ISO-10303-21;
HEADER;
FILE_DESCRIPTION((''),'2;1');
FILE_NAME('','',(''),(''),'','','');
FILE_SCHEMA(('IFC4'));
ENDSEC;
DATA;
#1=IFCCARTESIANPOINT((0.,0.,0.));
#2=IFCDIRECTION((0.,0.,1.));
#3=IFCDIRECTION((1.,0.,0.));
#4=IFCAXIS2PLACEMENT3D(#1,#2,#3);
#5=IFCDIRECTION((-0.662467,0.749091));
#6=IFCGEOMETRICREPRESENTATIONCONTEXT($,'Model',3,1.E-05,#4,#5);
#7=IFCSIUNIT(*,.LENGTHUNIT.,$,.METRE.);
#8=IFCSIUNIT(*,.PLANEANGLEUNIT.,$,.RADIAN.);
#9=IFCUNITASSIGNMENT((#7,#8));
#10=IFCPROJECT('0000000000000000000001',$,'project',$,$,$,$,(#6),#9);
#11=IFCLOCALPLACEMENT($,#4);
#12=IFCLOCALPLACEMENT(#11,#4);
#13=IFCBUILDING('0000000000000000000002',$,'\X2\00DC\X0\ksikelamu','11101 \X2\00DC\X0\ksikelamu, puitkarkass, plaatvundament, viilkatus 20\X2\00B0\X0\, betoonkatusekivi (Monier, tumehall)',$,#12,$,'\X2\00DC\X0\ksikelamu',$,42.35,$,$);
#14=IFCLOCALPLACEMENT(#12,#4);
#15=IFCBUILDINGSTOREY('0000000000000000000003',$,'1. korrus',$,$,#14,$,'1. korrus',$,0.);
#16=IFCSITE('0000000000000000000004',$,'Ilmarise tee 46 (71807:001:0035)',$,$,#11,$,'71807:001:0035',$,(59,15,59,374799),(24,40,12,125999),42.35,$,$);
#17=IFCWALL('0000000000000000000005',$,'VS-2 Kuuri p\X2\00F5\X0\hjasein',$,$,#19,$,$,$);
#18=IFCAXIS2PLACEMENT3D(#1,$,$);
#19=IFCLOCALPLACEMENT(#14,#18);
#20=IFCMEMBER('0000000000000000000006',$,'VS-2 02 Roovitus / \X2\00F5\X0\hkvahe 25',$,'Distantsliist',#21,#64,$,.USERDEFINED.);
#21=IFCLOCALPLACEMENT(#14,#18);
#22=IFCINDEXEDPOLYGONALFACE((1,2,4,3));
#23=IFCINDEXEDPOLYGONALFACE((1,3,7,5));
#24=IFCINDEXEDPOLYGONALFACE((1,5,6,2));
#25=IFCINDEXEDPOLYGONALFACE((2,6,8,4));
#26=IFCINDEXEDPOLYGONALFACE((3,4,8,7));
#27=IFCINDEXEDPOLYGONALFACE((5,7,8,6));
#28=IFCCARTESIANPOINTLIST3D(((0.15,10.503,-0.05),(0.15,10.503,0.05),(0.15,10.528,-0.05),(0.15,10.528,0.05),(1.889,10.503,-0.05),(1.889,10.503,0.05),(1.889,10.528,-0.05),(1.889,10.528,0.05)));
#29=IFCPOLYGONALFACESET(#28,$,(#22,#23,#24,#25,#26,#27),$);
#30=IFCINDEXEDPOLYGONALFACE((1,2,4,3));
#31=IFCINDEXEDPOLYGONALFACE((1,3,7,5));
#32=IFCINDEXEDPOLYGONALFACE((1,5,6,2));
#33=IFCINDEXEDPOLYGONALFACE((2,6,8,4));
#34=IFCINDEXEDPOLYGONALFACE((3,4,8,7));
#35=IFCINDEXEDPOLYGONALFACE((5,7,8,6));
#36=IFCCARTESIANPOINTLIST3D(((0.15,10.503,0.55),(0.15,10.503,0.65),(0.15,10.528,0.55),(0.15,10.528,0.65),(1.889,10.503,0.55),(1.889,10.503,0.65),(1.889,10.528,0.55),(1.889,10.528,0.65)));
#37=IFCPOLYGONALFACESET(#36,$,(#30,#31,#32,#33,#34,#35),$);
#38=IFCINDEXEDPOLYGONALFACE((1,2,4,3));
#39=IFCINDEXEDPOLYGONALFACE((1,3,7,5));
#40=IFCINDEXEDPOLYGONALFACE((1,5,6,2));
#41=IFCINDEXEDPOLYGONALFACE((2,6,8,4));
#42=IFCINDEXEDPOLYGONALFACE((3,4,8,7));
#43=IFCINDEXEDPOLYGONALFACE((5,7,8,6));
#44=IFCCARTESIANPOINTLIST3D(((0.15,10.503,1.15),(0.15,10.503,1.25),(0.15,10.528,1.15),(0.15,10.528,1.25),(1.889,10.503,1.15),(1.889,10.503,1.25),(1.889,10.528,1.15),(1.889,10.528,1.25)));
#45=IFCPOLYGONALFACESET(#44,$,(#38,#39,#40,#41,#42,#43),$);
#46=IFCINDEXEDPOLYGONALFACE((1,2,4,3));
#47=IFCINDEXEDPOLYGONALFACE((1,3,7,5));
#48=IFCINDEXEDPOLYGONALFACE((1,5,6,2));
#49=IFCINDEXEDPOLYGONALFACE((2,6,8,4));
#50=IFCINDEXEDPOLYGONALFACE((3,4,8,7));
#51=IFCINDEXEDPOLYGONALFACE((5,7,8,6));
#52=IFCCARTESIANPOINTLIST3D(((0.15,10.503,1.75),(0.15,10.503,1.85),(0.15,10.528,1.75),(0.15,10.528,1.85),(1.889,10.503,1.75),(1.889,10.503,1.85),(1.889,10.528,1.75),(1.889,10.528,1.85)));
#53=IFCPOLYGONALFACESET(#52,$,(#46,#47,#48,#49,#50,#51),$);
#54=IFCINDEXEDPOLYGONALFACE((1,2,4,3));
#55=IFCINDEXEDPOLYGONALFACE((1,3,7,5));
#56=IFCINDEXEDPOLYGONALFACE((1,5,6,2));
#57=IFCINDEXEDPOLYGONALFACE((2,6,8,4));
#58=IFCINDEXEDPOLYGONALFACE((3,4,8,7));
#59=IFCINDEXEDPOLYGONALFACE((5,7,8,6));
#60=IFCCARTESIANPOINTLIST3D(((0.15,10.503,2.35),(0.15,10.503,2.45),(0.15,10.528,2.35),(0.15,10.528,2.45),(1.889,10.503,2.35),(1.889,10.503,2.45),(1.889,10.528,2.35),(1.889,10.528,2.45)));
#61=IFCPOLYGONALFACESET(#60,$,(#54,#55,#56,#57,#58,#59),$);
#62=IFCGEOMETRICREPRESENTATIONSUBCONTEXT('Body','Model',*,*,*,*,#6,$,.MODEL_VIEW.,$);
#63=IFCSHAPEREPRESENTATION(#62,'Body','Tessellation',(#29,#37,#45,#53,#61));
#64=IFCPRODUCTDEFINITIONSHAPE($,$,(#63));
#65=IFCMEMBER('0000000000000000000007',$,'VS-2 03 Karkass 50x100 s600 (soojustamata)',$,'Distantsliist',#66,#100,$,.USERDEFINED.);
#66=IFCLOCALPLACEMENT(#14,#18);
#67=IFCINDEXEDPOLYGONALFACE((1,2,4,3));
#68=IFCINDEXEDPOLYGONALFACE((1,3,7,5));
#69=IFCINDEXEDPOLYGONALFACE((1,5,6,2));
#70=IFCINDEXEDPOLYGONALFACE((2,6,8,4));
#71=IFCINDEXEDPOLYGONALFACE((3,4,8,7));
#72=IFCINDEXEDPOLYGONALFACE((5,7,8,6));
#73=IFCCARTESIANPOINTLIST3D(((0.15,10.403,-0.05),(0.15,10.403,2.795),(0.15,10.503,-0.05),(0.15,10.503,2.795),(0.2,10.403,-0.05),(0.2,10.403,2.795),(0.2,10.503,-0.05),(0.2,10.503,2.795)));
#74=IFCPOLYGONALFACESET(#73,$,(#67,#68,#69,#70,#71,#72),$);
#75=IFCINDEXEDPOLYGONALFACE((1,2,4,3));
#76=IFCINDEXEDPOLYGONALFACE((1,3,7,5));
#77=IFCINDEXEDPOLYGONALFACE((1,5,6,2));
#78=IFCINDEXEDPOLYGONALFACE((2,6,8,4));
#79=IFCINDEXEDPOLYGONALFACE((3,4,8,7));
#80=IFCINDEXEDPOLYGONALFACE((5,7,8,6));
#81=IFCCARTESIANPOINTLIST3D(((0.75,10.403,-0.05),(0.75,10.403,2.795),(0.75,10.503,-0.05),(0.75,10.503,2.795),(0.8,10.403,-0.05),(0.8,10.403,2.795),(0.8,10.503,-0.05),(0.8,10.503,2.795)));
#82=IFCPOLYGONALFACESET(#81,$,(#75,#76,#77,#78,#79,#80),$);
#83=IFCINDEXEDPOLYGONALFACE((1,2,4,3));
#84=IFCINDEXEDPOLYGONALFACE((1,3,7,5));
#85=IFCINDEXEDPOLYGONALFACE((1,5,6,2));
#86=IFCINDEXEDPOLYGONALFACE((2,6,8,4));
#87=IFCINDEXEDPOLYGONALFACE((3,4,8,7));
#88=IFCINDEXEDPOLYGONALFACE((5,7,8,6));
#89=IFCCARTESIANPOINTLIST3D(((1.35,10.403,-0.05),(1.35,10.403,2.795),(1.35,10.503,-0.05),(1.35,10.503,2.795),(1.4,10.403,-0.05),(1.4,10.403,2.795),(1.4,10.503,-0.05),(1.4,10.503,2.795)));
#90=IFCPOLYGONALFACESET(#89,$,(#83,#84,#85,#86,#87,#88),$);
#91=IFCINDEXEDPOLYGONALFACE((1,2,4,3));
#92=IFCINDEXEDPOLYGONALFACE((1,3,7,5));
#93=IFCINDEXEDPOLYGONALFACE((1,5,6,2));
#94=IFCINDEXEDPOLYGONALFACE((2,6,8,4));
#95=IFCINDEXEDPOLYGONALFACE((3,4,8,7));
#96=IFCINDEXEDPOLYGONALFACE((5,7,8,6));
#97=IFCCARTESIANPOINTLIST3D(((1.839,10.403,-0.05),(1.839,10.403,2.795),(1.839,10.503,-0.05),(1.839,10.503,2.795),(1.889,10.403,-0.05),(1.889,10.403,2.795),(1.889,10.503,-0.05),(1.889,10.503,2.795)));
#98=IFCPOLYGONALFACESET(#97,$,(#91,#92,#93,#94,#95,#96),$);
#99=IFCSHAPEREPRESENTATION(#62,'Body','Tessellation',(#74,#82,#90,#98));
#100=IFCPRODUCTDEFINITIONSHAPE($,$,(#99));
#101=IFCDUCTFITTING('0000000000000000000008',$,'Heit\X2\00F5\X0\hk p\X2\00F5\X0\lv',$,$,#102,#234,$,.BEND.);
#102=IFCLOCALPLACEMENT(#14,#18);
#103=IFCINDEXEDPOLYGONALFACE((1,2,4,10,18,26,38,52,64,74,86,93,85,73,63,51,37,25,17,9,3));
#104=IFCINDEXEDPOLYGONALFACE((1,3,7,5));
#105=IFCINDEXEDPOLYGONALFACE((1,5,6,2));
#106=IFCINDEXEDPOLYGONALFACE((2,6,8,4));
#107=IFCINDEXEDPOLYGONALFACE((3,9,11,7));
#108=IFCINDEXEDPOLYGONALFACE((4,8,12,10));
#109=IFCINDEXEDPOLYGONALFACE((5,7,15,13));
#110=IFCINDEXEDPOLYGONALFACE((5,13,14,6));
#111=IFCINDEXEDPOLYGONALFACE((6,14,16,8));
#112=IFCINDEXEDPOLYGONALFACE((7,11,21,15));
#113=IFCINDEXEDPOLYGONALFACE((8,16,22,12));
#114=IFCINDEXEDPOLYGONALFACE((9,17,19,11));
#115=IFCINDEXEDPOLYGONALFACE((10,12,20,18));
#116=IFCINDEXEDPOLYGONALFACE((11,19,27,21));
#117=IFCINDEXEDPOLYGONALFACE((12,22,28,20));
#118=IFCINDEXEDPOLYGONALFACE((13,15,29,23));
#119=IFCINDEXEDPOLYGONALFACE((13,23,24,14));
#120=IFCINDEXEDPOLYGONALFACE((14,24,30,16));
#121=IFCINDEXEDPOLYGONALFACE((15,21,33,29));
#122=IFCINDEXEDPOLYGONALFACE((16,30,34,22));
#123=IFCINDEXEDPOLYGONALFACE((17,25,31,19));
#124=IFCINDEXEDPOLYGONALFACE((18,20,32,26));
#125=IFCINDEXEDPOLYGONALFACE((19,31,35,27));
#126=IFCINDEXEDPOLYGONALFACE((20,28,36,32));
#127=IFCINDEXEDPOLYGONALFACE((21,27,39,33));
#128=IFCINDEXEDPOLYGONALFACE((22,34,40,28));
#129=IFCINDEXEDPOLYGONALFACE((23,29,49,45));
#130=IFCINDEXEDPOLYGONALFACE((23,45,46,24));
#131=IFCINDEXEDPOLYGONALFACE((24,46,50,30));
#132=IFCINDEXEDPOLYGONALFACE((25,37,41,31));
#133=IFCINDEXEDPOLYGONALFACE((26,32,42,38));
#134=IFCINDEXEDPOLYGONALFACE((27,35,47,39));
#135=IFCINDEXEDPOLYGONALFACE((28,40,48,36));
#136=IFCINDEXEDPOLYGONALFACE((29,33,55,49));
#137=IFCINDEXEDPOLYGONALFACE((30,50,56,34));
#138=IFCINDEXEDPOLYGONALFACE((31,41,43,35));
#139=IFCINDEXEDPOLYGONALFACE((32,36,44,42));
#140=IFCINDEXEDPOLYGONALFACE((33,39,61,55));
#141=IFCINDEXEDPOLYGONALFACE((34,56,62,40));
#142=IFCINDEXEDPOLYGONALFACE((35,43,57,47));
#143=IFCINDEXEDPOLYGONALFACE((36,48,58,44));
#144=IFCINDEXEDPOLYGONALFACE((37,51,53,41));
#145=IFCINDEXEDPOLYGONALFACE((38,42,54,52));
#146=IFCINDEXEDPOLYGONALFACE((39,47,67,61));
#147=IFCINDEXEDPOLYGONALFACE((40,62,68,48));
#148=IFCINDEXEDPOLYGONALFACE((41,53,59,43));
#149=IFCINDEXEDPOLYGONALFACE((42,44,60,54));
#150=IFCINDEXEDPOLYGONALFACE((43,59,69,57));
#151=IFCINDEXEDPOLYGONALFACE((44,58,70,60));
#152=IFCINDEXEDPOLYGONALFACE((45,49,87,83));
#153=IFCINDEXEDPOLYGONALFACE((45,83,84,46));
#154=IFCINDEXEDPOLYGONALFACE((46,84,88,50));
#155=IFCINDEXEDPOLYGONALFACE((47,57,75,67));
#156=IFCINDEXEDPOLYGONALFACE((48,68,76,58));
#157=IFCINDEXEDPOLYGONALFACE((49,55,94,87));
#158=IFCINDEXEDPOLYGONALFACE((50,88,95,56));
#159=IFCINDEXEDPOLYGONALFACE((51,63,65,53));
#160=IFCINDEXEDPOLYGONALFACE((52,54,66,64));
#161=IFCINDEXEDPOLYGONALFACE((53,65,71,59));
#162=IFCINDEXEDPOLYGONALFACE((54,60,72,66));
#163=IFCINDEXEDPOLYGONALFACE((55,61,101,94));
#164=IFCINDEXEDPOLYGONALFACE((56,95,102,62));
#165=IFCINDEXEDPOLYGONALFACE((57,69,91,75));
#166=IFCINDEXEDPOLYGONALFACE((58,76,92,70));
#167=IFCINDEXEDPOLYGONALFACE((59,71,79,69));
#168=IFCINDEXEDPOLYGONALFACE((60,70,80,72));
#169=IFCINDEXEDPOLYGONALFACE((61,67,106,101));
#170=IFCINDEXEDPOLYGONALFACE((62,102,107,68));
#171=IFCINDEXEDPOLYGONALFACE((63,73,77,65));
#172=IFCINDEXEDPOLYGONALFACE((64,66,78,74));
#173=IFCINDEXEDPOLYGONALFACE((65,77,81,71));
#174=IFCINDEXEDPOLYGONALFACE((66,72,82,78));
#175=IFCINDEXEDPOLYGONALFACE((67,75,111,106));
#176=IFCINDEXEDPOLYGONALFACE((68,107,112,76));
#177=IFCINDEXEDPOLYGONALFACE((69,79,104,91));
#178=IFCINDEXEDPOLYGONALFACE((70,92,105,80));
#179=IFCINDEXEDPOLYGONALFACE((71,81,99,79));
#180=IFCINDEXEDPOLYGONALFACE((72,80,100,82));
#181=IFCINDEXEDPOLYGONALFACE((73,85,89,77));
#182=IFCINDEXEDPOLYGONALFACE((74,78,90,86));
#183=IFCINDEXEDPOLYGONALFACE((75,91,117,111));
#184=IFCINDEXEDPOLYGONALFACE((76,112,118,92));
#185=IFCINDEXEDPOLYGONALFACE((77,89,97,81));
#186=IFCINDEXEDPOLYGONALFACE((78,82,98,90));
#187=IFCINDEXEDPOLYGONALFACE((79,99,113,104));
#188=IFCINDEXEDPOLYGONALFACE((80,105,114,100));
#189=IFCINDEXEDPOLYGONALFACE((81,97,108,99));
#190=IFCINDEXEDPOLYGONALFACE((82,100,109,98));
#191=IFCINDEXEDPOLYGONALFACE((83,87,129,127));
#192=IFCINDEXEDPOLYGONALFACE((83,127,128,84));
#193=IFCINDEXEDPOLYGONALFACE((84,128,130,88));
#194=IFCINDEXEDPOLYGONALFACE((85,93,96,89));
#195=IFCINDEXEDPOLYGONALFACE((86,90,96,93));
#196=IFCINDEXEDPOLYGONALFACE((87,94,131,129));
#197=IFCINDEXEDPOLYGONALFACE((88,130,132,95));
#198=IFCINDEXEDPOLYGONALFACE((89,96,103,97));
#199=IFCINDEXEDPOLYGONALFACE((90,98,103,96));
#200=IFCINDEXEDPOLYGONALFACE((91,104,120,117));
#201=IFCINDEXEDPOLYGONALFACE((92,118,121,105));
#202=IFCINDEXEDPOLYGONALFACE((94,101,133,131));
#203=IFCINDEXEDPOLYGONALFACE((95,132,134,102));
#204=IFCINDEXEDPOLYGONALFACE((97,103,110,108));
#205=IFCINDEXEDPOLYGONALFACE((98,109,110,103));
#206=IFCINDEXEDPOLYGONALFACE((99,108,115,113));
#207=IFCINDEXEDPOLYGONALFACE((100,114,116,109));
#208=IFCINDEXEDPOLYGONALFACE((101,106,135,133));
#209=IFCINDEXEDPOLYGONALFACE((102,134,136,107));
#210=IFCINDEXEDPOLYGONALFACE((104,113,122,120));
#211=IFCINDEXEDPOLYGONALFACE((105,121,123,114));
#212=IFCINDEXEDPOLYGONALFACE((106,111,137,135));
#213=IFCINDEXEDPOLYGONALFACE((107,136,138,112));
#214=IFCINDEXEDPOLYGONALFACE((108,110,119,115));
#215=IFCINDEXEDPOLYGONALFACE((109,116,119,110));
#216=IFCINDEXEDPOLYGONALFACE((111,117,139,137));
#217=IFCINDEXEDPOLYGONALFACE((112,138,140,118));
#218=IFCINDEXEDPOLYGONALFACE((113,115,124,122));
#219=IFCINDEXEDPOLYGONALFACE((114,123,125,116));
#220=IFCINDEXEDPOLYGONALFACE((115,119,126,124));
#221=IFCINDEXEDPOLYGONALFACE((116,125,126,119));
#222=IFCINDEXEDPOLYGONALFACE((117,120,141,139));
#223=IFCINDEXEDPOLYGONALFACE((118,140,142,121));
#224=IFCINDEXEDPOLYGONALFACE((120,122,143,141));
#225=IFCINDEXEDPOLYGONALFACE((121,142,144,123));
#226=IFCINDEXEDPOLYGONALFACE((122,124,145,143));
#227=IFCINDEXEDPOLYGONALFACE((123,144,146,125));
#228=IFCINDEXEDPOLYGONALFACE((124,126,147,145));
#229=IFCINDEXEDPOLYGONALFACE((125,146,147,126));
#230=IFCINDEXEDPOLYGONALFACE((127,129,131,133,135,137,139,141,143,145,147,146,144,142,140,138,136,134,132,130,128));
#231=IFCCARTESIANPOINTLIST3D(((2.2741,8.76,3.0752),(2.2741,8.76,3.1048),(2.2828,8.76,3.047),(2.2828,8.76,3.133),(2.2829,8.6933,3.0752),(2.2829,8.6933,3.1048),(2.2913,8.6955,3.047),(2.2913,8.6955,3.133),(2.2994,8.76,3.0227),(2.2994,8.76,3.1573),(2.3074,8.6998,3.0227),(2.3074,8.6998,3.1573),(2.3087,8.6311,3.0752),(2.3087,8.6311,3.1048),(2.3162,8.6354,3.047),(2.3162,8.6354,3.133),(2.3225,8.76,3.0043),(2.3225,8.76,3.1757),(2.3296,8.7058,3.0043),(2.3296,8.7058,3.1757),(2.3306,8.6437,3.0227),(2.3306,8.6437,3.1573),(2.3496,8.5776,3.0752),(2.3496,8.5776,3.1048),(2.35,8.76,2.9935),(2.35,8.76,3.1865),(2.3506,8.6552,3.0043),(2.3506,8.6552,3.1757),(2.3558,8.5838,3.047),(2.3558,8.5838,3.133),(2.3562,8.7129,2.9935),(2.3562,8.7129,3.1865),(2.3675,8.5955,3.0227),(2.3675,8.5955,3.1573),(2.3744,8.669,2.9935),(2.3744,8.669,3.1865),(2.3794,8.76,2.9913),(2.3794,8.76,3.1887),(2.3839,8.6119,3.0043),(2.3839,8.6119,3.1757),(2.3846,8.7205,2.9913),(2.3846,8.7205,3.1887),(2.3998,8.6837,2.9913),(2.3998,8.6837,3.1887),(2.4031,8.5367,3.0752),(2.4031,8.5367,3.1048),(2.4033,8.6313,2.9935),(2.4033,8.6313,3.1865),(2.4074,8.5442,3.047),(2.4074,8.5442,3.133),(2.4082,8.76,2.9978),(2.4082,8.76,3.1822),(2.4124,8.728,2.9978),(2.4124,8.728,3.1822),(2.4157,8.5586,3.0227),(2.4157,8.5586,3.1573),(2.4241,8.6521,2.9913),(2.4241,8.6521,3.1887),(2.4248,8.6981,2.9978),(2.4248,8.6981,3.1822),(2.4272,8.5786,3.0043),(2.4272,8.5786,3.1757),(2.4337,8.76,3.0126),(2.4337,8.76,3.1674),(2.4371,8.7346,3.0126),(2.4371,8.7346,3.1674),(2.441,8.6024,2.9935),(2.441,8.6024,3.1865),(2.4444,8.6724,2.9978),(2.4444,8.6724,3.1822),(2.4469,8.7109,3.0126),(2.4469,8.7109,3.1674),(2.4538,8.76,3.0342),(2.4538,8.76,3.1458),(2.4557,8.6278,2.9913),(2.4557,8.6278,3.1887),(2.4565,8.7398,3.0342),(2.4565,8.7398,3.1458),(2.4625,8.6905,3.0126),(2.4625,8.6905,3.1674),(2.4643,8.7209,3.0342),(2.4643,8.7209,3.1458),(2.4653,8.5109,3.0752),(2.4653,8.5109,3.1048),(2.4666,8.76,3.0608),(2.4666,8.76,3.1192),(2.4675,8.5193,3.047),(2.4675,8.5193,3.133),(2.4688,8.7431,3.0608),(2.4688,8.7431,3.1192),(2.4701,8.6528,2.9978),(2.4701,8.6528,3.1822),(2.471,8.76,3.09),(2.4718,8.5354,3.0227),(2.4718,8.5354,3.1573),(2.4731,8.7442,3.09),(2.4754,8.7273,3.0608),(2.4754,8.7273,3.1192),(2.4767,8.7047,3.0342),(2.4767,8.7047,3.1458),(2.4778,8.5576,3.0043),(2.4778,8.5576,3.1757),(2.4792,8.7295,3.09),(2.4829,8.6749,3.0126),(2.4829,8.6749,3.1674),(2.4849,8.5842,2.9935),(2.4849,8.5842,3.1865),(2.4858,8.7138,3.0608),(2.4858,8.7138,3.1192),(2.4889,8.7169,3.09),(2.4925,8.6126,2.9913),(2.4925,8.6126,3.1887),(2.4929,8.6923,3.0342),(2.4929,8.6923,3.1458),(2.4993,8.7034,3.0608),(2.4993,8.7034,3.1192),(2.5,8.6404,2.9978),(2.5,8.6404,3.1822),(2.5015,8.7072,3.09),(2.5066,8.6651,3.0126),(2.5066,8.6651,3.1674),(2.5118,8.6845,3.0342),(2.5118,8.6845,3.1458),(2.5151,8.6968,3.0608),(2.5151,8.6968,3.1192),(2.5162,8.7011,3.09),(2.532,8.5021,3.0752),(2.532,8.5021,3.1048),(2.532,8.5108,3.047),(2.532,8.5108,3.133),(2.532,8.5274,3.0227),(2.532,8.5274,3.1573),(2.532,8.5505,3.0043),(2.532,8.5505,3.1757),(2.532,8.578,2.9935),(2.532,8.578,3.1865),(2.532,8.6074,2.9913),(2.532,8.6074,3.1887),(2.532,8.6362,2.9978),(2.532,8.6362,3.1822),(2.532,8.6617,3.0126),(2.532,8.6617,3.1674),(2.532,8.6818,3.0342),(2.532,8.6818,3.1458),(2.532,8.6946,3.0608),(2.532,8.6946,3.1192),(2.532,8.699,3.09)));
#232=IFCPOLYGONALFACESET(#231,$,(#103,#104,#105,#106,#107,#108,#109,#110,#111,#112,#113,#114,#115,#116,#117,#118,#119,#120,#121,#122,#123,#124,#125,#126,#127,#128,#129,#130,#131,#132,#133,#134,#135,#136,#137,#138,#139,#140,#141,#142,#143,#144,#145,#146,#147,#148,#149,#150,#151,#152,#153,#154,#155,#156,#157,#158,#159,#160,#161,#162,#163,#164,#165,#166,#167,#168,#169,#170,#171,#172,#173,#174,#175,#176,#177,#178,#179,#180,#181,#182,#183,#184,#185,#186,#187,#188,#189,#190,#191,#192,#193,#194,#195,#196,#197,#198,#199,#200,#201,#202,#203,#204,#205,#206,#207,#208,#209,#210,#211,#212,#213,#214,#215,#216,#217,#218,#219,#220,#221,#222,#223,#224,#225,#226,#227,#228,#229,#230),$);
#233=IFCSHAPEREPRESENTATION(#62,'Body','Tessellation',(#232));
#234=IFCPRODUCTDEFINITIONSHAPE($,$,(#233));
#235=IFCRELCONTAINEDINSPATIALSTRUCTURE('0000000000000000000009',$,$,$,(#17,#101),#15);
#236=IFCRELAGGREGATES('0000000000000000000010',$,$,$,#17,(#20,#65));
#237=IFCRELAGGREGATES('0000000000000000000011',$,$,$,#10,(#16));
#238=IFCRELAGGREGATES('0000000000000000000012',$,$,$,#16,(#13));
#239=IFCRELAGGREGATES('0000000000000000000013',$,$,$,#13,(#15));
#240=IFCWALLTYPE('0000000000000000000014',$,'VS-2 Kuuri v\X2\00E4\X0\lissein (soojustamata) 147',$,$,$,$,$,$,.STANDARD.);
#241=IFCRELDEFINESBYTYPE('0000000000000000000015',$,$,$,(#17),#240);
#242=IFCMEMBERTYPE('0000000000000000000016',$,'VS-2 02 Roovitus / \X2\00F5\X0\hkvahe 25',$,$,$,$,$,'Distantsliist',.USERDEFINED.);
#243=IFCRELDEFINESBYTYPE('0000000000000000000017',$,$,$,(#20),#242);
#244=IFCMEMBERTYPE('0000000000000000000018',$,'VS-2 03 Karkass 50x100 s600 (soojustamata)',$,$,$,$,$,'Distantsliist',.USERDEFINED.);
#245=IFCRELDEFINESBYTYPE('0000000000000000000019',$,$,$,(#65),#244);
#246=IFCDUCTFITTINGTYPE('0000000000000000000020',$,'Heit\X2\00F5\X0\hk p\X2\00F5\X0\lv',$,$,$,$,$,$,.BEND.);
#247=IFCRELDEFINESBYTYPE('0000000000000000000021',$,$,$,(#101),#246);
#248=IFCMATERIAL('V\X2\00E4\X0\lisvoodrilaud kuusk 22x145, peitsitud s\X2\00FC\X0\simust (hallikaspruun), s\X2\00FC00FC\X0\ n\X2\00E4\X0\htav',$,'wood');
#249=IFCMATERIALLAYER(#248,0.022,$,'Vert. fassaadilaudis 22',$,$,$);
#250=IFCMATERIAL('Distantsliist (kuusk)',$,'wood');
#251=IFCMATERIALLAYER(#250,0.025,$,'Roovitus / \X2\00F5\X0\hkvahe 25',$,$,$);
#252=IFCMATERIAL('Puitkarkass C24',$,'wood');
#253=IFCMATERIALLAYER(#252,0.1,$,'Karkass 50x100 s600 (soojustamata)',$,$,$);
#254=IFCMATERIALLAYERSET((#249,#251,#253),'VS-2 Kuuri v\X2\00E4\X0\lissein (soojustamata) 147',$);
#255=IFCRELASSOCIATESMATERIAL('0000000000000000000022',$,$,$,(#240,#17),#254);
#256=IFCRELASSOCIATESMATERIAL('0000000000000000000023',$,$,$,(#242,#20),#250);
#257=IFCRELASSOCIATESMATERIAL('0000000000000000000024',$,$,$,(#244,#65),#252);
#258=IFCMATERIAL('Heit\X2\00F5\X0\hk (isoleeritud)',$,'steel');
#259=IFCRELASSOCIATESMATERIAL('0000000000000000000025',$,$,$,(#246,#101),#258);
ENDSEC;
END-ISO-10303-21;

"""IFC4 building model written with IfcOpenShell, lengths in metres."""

from ifc_helpers import new_model, entity, si_unit, direction, frame, origin_with_axes, place, context, subcontext, project, spatial, indexed_curve, outline, extrude, material, layer, layer_set, layer_usage, type_object, element, aggregate, save


model = new_model("IFC4")

# Units and contexts
model_context = context("Model", 3, precision=1e-05, world=origin_with_axes(), true_north=direction((-0.662467, 0.749091)))
body_context = subcontext(model_context, "Body", "Model", "MODEL_VIEW")
ifc_project = project(units=[si_unit("LENGTHUNIT", "METRE"), si_unit("PLANEANGLEUNIT", "RADIAN")], contexts=[model_context])

# Site, building, storey
site_placement = place(None, origin_with_axes())
site = spatial("IfcSite", under=ifc_project, at=site_placement, Name="Ilmarise tee 46 (71807:001:0035)", LongName="71807:001:0035", RefLatitude=(59, 15, 59, 374799), RefLongitude=(24, 40, 12, 125999), RefElevation=42.35)
building_placement = place(site_placement, origin_with_axes())
building = spatial("IfcBuilding", under=site, at=building_placement, Name="Üksikelamu", Description="11101 Üksikelamu, puitkarkass, plaatvundament, viilkatus 20°, betoonkatusekivi (Monier, tumehall)", LongName="Üksikelamu", ElevationOfRefHeight=42.35)
storey_placement = place(building_placement, origin_with_axes())
storey = spatial("IfcBuildingStorey", under=building, at=storey_placement, Name="1. korrus", LongName="1. korrus", Elevation=0.0)

# Wall, members
ifc_material_1 = material(Name="Välisvoodrilaud kuusk 22x145, peitsitud süsimust (hallikaspruun), süü nähtav", Category="wood")
ifc_layer_1 = layer(ifc_material_1, 0.022, Name="Vert. fassaadilaudis 22")
ifc_material_2 = material(Name="Distantsliist (kuusk)", Category="wood")
ifc_layer_2 = layer(ifc_material_2, 0.025, Name="Roovitus / õhkvahe 25")
ifc_material_3 = material(Name="Puitkarkass C24", Category="wood")
ifc_layer_3 = layer(ifc_material_3, 0.1, Name="Karkass 50x100 s600 (soojustamata)")
ifc_layer_set = layer_set([ifc_layer_1, ifc_layer_2, ifc_layer_3], Name="VS-2 Kuuri välissein (soojustamata) 147")
ifc_layer_usage = layer_usage(ifc_layer_set, "AXIS2", "NEGATIVE", 0.0)
wall_type = type_object("IfcWallType", Name="VS-2 Kuuri välissein (soojustamata) 147", PredefinedType="STANDARD", material=ifc_layer_set)
wall_placement = place(storey_placement, frame((0.0, 10.55, 0.0), z_axis=(0.0, 0.0, 1.0), x_axis=(1.0, 0.0, 0.0)))
wall = element("IfcWall", 1, at=wall_placement, inside=storey, type_object=wall_type, material=ifc_layer_usage, Name="VS-2 Kuuri põhjasein")
member_type_1 = type_object("IfcMemberType", Name="VS-2 02 Roovitus / õhkvahe 25", ElementType="Distantsliist", PredefinedType="USERDEFINED", material=ifc_material_2)
member_1_placement = place(wall_placement, origin_with_axes())
member_1 = element("IfcMember", 2, at=member_1_placement, type_object=member_type_1, material=ifc_material_2, Name="VS-2 02 Roovitus / õhkvahe 25", ObjectType="Distantsliist", PredefinedType="USERDEFINED", context=body_context, shape_type="SweptSolid", body=[
    extrude(outline(indexed_curve([(1.889, -0.05), (0.15, -0.05), (0.15, 0.05), (1.889, 0.05), (1.889, -0.05)], self_intersect=False)), frame((0.0, -0.022, 0.0), z_axis=(0.0, -1.0, 0.0), x_axis=(1.0, 0.0, 0.0)), (0.0, 0.0, 1.0), 0.025),
    extrude(outline(indexed_curve([(1.889, 0.55), (0.15, 0.55), (0.15, 0.65), (1.889, 0.65), (1.889, 0.55)], self_intersect=False)), frame((0.0, -0.022, 0.0), z_axis=(0.0, -1.0, 0.0), x_axis=(1.0, 0.0, 0.0)), (0.0, 0.0, 1.0), 0.025),
    extrude(outline(indexed_curve([(1.889, 1.15), (0.15, 1.15), (0.15, 1.25), (1.889, 1.25), (1.889, 1.15)], self_intersect=False)), frame((0.0, -0.022, 0.0), z_axis=(0.0, -1.0, 0.0), x_axis=(1.0, 0.0, 0.0)), (0.0, 0.0, 1.0), 0.025),
    extrude(outline(indexed_curve([(1.889, 1.75), (0.15, 1.75), (0.15, 1.85), (1.889, 1.85), (1.889, 1.75)], self_intersect=False)), frame((0.0, -0.022, 0.0), z_axis=(0.0, -1.0, 0.0), x_axis=(1.0, 0.0, 0.0)), (0.0, 0.0, 1.0), 0.025),
    extrude(outline(indexed_curve([(1.889, 2.35), (0.15, 2.35), (0.15, 2.45), (1.889, 2.45), (1.889, 2.35)], self_intersect=False)), frame((0.0, -0.022, 0.0), z_axis=(0.0, -1.0, 0.0), x_axis=(1.0, 0.0, 0.0)), (0.0, 0.0, 1.0), 0.025),
])
member_type_2 = type_object("IfcMemberType", Name="VS-2 03 Karkass 50x100 s600 (soojustamata)", ElementType="Distantsliist", PredefinedType="USERDEFINED", material=ifc_material_3)
member_2_placement = place(wall_placement, origin_with_axes())
member_2 = element("IfcMember", 3, at=member_2_placement, type_object=member_type_2, material=ifc_material_3, Name="VS-2 03 Karkass 50x100 s600 (soojustamata)", ObjectType="Distantsliist", PredefinedType="USERDEFINED", context=body_context, shape_type="SweptSolid", body=[
    extrude(outline(indexed_curve([(0.2, -0.05), (0.15, -0.05), (0.15, 2.795), (0.2, 2.795), (0.2, -0.05)], self_intersect=False)), frame((0.0, -0.047, 0.0), z_axis=(0.0, -1.0, 0.0), x_axis=(1.0, 0.0, 0.0)), (0.0, 0.0, 1.0), 0.1),
    extrude(outline(indexed_curve([(0.8, -0.05), (0.75, -0.05), (0.75, 2.795), (0.8, 2.795), (0.8, -0.05)], self_intersect=False)), frame((0.0, -0.047, 0.0), z_axis=(0.0, -1.0, 0.0), x_axis=(1.0, 0.0, 0.0)), (0.0, 0.0, 1.0), 0.1),
    extrude(outline(indexed_curve([(1.4, -0.05), (1.35, -0.05), (1.35, 2.795), (1.4, 2.795), (1.4, -0.05)], self_intersect=False)), frame((0.0, -0.047, 0.0), z_axis=(0.0, -1.0, 0.0), x_axis=(1.0, 0.0, 0.0)), (0.0, 0.0, 1.0), 0.1),
    extrude(outline(indexed_curve([(1.889, -0.05), (1.839, -0.05), (1.839, 2.795), (1.889, 2.795), (1.889, -0.05)], self_intersect=False)), frame((0.0, -0.047, 0.0), z_axis=(0.0, -1.0, 0.0), x_axis=(1.0, 0.0, 0.0)), (0.0, 0.0, 1.0), 0.1),
])

# Duct fitting
ifc_material_4 = material(Name="Heitõhk (isoleeritud)", Category="steel")
duct_fitting_type = type_object("IfcDuctFittingType", Name="Heitõhk põlv", PredefinedType="BEND", material=ifc_material_4)
duct_fitting_placement = place(storey_placement, frame((2.372, 8.6, 3.09), z_axis=(0.0, 0.0, 1.0), x_axis=(1.0, 0.0, 0.0)))
element("IfcDuctFitting", 4, at=duct_fitting_placement, inside=storey, type_object=duct_fitting_type, material=ifc_material_4, Name="Heitõhk põlv", PredefinedType="BEND", context=body_context, shape_type="SweptSolid", body=[
    entity("IfcRevolvedAreaSolid", entity("IfcCircleProfileDef", "AREA", None, None, 0.099), entity("IfcAxis2Placement3D", entity("IfcCartesianPoint", [0.0, 0.16, 0.0]), entity("IfcDirection", [0.0, -1.0, 0.0]), entity("IfcDirection", [1.0, 0.0, 0.0])), entity("IfcAxis1Placement", entity("IfcCartesianPoint", [0.16, 0.0, 0.0]), entity("IfcDirection", [0.0, 1.0, 0.0])), 1.570796),
])

aggregate(wall, [member_1, member_2])

save(model, "model.ifc")
